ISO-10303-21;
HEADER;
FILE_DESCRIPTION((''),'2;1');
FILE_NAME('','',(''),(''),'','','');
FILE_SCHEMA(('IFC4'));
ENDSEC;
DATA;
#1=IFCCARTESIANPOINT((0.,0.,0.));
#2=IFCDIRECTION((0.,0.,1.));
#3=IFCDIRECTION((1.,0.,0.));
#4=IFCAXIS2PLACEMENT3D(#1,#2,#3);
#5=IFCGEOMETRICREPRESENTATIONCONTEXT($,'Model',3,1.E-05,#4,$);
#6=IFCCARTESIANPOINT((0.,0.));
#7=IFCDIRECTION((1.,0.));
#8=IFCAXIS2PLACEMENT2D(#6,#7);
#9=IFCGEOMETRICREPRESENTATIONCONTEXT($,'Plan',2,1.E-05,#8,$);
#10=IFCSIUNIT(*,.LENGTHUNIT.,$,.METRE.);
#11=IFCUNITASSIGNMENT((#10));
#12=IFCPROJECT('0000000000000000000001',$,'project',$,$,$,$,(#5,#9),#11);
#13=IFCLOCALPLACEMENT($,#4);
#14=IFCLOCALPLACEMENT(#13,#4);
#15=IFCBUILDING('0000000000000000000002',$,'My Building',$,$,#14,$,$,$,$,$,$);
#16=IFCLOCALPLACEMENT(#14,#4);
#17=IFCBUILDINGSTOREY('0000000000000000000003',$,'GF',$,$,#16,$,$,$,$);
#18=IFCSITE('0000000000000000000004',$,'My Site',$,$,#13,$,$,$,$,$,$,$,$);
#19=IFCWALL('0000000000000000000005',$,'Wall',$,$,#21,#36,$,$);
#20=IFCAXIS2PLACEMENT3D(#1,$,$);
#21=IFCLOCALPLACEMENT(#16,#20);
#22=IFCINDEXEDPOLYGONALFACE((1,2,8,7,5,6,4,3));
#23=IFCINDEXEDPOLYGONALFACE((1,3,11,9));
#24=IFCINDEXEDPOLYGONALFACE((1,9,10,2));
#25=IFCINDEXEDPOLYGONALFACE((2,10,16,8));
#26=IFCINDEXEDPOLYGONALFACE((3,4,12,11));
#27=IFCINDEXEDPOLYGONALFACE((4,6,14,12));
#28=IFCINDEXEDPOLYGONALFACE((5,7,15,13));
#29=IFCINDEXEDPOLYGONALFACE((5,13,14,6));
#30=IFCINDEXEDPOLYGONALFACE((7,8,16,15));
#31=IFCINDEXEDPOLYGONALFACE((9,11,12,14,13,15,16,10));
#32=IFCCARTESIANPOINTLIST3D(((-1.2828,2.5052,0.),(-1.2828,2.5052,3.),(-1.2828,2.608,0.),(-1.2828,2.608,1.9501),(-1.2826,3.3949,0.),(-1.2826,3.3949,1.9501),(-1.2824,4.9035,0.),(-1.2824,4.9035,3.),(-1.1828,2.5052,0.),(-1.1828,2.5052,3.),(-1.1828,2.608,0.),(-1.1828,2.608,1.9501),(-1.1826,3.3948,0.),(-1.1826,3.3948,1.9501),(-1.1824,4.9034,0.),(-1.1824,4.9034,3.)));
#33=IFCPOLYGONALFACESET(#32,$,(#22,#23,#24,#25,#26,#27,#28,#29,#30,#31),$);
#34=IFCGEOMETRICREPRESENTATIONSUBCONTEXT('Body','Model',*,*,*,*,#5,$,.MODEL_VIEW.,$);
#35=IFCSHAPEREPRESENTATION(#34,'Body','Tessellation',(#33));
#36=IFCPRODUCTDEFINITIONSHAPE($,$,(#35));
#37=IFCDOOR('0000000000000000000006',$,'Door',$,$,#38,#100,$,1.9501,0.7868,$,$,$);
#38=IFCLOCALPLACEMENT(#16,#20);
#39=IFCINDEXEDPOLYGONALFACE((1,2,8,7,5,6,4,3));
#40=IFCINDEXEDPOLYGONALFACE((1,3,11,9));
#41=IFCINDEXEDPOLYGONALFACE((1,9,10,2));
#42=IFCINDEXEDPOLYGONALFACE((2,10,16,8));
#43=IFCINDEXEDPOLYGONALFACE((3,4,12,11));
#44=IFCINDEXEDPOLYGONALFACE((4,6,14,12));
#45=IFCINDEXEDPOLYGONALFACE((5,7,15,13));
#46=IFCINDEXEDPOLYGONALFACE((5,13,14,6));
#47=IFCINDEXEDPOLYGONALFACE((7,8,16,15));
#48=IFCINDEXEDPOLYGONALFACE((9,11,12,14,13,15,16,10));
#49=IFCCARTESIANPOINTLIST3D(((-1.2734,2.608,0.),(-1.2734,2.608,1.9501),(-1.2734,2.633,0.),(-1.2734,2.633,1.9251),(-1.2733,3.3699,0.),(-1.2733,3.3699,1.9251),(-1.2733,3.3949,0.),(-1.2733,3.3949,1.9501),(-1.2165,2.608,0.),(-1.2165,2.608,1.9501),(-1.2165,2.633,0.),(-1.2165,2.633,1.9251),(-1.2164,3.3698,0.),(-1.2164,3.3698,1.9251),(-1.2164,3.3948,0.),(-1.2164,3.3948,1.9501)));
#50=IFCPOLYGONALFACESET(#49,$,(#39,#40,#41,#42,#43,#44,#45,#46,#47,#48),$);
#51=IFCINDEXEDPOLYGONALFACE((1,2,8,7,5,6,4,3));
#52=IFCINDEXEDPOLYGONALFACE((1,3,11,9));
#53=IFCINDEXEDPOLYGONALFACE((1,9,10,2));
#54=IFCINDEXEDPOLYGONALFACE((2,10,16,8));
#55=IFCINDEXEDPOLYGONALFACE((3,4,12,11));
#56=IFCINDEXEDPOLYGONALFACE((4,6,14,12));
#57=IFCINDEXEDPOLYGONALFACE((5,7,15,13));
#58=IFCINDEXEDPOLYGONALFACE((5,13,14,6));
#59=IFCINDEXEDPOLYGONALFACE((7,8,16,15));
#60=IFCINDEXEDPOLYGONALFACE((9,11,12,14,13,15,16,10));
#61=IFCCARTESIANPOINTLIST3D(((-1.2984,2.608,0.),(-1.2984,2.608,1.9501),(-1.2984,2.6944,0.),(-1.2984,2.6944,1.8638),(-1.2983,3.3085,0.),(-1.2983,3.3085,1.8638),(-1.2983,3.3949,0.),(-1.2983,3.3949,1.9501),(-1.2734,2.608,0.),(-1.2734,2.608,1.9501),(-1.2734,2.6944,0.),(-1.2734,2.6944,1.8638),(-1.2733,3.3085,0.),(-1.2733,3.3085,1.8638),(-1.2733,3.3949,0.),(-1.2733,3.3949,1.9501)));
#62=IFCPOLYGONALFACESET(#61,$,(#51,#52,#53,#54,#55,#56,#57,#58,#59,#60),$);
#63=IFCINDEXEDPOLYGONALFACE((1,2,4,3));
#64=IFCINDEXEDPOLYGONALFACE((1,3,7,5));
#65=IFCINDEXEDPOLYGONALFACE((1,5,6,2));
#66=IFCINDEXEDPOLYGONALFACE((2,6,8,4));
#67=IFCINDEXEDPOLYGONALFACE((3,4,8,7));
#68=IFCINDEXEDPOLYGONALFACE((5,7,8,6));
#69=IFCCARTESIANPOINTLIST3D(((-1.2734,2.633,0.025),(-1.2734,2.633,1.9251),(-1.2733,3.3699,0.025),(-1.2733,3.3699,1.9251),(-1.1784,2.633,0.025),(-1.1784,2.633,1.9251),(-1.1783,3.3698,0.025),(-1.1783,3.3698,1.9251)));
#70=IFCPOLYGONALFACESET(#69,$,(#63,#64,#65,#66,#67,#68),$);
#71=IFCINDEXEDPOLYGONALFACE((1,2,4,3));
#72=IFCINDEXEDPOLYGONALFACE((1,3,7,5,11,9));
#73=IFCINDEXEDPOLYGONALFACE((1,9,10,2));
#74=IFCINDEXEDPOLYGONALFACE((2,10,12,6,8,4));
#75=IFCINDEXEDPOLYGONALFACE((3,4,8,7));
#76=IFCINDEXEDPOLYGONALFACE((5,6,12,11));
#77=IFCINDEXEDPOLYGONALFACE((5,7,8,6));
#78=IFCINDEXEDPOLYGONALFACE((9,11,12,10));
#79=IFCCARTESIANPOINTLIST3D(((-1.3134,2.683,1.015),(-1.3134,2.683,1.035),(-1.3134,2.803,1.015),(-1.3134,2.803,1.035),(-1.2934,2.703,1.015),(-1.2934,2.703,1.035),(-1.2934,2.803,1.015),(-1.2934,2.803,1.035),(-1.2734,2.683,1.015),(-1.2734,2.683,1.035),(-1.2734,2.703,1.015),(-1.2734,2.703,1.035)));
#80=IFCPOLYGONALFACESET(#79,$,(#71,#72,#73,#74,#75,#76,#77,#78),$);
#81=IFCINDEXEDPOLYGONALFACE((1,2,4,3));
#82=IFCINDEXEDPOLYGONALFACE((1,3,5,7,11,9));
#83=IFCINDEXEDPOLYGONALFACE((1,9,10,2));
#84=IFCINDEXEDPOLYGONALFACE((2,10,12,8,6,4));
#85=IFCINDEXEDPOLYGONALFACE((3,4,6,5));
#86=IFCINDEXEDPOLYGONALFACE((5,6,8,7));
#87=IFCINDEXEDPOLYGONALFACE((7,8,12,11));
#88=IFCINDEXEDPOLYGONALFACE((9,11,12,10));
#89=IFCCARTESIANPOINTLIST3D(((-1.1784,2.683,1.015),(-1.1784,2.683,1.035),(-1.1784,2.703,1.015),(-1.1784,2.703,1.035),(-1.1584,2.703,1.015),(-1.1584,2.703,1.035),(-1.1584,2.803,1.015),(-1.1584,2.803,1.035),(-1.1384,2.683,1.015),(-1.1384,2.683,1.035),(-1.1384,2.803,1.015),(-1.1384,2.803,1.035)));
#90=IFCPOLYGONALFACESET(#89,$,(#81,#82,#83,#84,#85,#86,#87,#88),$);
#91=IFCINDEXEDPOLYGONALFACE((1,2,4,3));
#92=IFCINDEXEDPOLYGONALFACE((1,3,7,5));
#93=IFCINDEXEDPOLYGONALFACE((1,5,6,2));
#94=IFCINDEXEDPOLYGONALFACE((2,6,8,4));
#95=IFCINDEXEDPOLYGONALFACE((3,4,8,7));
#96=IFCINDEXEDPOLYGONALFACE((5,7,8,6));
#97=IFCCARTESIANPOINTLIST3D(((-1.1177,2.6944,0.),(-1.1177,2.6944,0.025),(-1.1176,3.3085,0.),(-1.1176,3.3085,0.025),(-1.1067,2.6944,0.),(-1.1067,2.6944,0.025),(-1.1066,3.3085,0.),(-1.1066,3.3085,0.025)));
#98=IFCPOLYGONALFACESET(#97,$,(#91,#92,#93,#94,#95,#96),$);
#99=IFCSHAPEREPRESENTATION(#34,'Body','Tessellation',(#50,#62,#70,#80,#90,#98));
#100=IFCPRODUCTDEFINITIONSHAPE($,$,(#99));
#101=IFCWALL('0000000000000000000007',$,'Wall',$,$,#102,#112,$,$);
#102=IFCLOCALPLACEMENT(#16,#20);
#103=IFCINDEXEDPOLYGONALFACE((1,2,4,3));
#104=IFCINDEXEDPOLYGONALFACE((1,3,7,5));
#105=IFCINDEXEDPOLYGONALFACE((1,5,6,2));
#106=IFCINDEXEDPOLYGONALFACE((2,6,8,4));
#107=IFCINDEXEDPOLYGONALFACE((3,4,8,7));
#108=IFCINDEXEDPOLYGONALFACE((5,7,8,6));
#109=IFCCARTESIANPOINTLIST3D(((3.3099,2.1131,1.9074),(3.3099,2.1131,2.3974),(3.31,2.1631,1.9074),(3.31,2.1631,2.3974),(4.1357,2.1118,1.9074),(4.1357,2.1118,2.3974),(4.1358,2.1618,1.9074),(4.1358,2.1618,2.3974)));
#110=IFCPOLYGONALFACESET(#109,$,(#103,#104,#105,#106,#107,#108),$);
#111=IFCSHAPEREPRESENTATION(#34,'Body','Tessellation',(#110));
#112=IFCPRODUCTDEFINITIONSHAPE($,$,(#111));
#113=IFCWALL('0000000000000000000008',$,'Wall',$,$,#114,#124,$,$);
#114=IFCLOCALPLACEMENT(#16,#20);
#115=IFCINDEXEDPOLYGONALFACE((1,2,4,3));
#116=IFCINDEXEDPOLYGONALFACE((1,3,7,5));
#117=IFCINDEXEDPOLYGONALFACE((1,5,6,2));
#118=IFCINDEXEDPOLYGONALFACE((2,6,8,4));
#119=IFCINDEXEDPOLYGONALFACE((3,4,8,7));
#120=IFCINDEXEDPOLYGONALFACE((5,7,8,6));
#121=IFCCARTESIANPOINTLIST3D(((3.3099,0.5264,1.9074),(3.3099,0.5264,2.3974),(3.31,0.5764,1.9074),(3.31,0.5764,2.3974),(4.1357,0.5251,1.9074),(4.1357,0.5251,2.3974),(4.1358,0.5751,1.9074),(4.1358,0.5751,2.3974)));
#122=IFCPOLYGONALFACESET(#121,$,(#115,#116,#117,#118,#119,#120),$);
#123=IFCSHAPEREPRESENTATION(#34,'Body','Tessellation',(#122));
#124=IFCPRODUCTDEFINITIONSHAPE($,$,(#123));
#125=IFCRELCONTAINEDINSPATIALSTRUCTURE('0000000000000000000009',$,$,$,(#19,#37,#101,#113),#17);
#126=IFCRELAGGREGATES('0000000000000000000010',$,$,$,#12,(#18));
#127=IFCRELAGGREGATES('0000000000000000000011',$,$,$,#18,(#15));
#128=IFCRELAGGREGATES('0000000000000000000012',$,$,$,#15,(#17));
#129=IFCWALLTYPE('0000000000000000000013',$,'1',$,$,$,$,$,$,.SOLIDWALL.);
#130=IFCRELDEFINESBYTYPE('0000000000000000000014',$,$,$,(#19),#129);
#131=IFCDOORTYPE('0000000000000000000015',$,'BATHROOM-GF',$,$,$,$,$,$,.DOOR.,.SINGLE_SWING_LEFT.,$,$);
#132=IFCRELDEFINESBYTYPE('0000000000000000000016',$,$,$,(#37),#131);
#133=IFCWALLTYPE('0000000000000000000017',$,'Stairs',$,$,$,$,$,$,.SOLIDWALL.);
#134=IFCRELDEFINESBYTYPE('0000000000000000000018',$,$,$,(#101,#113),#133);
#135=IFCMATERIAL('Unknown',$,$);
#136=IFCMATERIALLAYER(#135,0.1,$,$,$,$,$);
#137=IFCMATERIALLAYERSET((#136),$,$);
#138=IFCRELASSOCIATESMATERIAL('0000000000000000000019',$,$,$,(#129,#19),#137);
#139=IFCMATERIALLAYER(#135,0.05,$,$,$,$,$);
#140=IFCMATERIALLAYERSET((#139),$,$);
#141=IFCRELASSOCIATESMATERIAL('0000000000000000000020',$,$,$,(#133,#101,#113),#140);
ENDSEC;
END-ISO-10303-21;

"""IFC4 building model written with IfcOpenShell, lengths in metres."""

from ifc_helpers import new_model, entity, si_unit, frame, origin_with_axes, origin_2d_with_axis, place, context, subcontext, project, spatial, line, indexed_curve, outline, extrude, shape, source, transform, mapped, material, layer, layer_set, layer_usage, type_object, type_shapes, element, fill, save


model = new_model("IFC4")

# Units and contexts
model_context = context("Model", 3, precision=1e-05, world=origin_with_axes())
plan_context = context("Plan", 2, precision=1e-05, world=origin_2d_with_axis())
body_context_1 = subcontext(model_context, "Body", "Model", "MODEL_VIEW")
body_context_2 = subcontext(plan_context, "Body", "Plan", "PLAN_VIEW")
ifc_project = project(units=[si_unit("LENGTHUNIT", "METRE")], contexts=[model_context, plan_context])

# Site, building, storey
site_placement = place(None, origin_with_axes())
site = spatial("IfcSite", under=ifc_project, at=site_placement, Name="My Site")
building_placement = place(site_placement, origin_with_axes())
building = spatial("IfcBuilding", under=site, at=building_placement, Name="My Building")
storey_placement = place(building_placement, origin_with_axes())
storey = spatial("IfcBuildingStorey", under=building, at=storey_placement, Name="GF")

# Shared definitions
ifc_material = material(Name="Unknown")

# Wall, opening, door
ifc_layer_1 = layer(ifc_material, 0.1)
ifc_layer_set_1 = layer_set([ifc_layer_1])
ifc_layer_usage_1 = layer_usage(ifc_layer_set_1, "AXIS2", "POSITIVE", 0.0)
wall_type_1 = type_object("IfcWallType", Name="1", PredefinedType="SOLIDWALL", material=ifc_layer_set_1)
wall_1_placement = place(storey_placement, frame((-1.1828, 2.5052, 0.0), z_axis=(0.0, 0.0, 1.0), x_axis=(0.000169, 1.0, 0.0)))
wall_1 = element("IfcWall", 1, at=wall_1_placement, inside=storey, type_object=wall_type_1, material=ifc_layer_usage_1, Name="Wall", context=body_context_1, shape_type="SweptSolid", body=[
    extrude(outline(indexed_curve([(0.0, 0.0), (0.0, 0.1), (2.3983, 0.1), (2.3983, 0.0)], segments=[line(1, 2, 3, 4, 1)])), origin_with_axes(), (0.0, 0.0, 1.0), 3.0),
])
shared_shape_1 = source(origin_with_axes(), body_context_1, "Body", "SweptSolid", [
    extrude(outline(indexed_curve([(0.0, 0.0), (0.7868, 0.0), (0.7868, 1.9501), (0.0, 1.9501)], segments=[line(1, 2, 3, 4, 1)])), frame((0.0, -0.6, 0.0), z_axis=(0.0, -1.0, 0.0), x_axis=(1.0, 0.0, 0.0)), (0.0, 0.0, -1.0), 1.2),
])
opening_1_placement = place(wall_1_placement, frame((0.8897, 0.1, 0.0), z_axis=(0.0, 0.0, 1.0), x_axis=(-1.0, 0.0, 0.0)))
opening_1 = element("IfcOpeningElement", 2, at=opening_1_placement, cuts=wall_1, PredefinedType="OPENING", context=body_context_1, shape_type="MappedRepresentation", body=[
    mapped(shared_shape_1, transform((0.0, 0.0, 0.0), x_axis=(1.0, 0.0, 0.0), y_axis=(0.0, 1.0, 0.0), z_axis=(0.0, 0.0, 1.0), scale=1.0)),
])
door_type_1 = type_object("IfcDoorType", Name="BATHROOM-GF", OperationType="SINGLE_SWING_LEFT", PredefinedType="DOOR")
shared_shape_2 = source(origin_with_axes(), body_context_1, "Body", "SweptSolid", [
    extrude(outline(indexed_curve([(0.0, 0.0), (0.0, 1.9501), (0.7868, 1.9501), (0.7868, 0.0), (0.7618, 0.0), (0.7618, 1.9251), (0.025, 1.9251), (0.025, 0.0)], segments=[line(1, 2, 3, 4, 5, 6, 7, 8, 1)])), frame((0.0, 0.0093, 0.0), z_axis=(0.0, -1.0, 0.0), x_axis=(1.0, 0.0, 0.0)), (0.0, 0.0, -1.0), 0.0569),
    extrude(outline(indexed_curve([(0.0, 0.0), (0.0, 1.9501), (0.7868, 1.9501), (0.7868, 0.0), (0.7005, 0.0), (0.7005, 1.8638), (0.0864, 1.8638), (0.0864, 0.0)], segments=[line(1, 2, 3, 4, 5, 6, 7, 8, 1)])), frame((0.0, -0.0157, 0.0), z_axis=(0.0, -1.0, 0.0), x_axis=(1.0, 0.0, 0.0)), (0.0, 0.0, -1.0), 0.025),
    extrude(outline(indexed_curve([(0.0, 0.0), (0.7368, 0.0), (0.7368, 0.095), (0.0, 0.095)], segments=[line(1, 2, 3, 4, 1)])), frame((0.025, 0.0093, 0.025), z_axis=(0.0, 0.0, 1.0), x_axis=(1.0, 0.0, 0.0)), (0.0, 0.0, 1.0), 1.9001),
    extrude(outline(indexed_curve([(0.0, 0.0), (0.0, -0.04), (-0.12, -0.04), (-0.12, -0.02), (-0.02, -0.02), (-0.02, 0.0)], segments=[line(1, 2, 3, 4, 5, 6, 1)])), frame((0.7118, 0.0093, 1.015), z_axis=(0.0, 0.0, 1.0), x_axis=(1.0, 0.0, 0.0)), (0.0, 0.0, 1.0), 0.02),
    extrude(outline(indexed_curve([(0.0, 0.0), (0.0, 0.04), (-0.12, 0.04), (-0.12, 0.02), (-0.02, 0.02), (-0.02, 0.0)], segments=[line(1, 2, 3, 4, 5, 6, 1)])), frame((0.7118, 0.1043, 1.015), z_axis=(0.0, 0.0, 1.0), x_axis=(1.0, 0.0, 0.0)), (0.0, 0.0, 1.0), 0.02),
    extrude(outline(indexed_curve([(0.0, 0.0), (0.6141, 0.0), (0.6141, 0.011), (0.0, 0.011)], segments=[line(1, 2, 3, 4, 1)])), frame((0.0864, 0.165, 0.0), z_axis=(0.0, 0.0, 1.0), x_axis=(1.0, 0.0, 0.0)), (0.0, 0.0, 1.0), 0.025),
])
shared_shape_3 = source(origin_with_axes(), body_context_2, "Body", "Curve2D", [
    entity("IfcIndexedPolyCurve", entity("IfcCartesianPointList2D", [[0.0, -0.0157], [0.0, 0.0662], [0.025, 0.0662], [0.025, 0.0093], [0.0864, 0.0093], [0.0864, -0.0157]]), [entity("IfcLineIndex", [1, 2, 3, 4, 5, 6, 1])]),
    entity("IfcIndexedPolyCurve", entity("IfcCartesianPointList2D", [[0.7868, -0.0157], [0.7868, 0.0662], [0.7618, 0.0662], [0.7618, 0.0093], [0.7005, 0.0093], [0.7005, -0.0157]]), [entity("IfcLineIndex", [1, 2, 3, 4, 5, 6, 1])]),
    entity("IfcTrimmedCurve", entity("IfcEllipse", entity("IfcAxis2Placement2D", entity("IfcCartesianPoint", [0.12, 0.0662]), entity("IfcDirection", [1.0, 0.0])), 0.6418, 0.7368), [entity("IfcCartesianPoint", [0.7618, 0.0662])], [entity("IfcCartesianPoint", [0.12, 0.803])], True, "CARTESIAN"),
    entity("IfcIndexedPolyCurve", entity("IfcCartesianPointList2D", [[0.025, 0.0662], [0.12, 0.0662], [0.12, 0.803], [0.025, 0.803]]), [entity("IfcLineIndex", [1, 2, 3, 4, 1])]),
])
type_shapes(door_type_1, [shared_shape_2, shared_shape_3])
door_1_placement = place(opening_1_placement, frame((0.0, 0.0, 0.0), z_axis=(0.0, 0.0, 1.0), x_axis=(1.0, 0.0, 0.0)))
door_1 = element("IfcDoor", 3, at=door_1_placement, inside=storey, type_object=door_type_1, Name="Door", OverallHeight=1.9501, OverallWidth=0.7868, shapes=[
    shape(body_context_1, "Body", "MappedRepresentation", [mapped(shared_shape_2, transform((0.0, 0.0, 0.0), x_axis=(1.0, 0.0, 0.0), y_axis=(0.0, 1.0, 0.0), z_axis=(0.0, 0.0, 1.0), scale=1.0))]),
    shape(body_context_2, "Body", "MappedRepresentation", [mapped(shared_shape_3, transform((0.0, 0.0, 0.0), x_axis=(1.0, 0.0, 0.0), y_axis=(0.0, 1.0, 0.0), z_axis=(0.0, 0.0, 1.0), scale=1.0))]),
])
fill(opening_1, door_1)

# Walls
ifc_layer_2 = layer(ifc_material, 0.05)
ifc_layer_set_2 = layer_set([ifc_layer_2])
ifc_layer_usage_2 = layer_usage(ifc_layer_set_2, "AXIS2", "POSITIVE", 0.0)
wall_type_2 = type_object("IfcWallType", Name="Stairs", PredefinedType="SOLIDWALL", material=ifc_layer_set_2)
wall_2_placement = place(storey_placement, frame((3.3099, 2.1131, 1.9074), z_axis=(0.0, 0.0, 1.0), x_axis=(0.999999, -0.001614, 0.0)))
element("IfcWall", 4, at=wall_2_placement, inside=storey, type_object=wall_type_2, material=ifc_layer_usage_2, Name="Wall", context=body_context_1, shape_type="SweptSolid", body=[
    extrude(outline(indexed_curve([(0.0, 0.0), (0.0, 0.05), (0.8258, 0.05), (0.8258, 0.0)], segments=[line(1, 2, 3, 4, 1)])), origin_with_axes(), (0.0, 0.0, 1.0), 0.49),
])
ifc_layer_usage_3 = layer_usage(ifc_layer_set_2, "AXIS2", "POSITIVE", 0.0)
wall_3_placement = place(storey_placement, frame((3.3099, 0.5264, 1.9074), z_axis=(0.0, 0.0, 1.0), x_axis=(0.999999, -0.001614, 0.0)))
element("IfcWall", 5, at=wall_3_placement, inside=storey, type_object=wall_type_2, material=ifc_layer_usage_3, Name="Wall", context=body_context_1, shape_type="SweptSolid", body=[
    extrude(outline(indexed_curve([(0.0, 0.0), (0.0, 0.05), (0.8258, 0.05), (0.8258, 0.0)], segments=[line(1, 2, 3, 4, 1)])), origin_with_axes(), (0.0, 0.0, 1.0), 0.49),
])

save(model, "model.ifc")
